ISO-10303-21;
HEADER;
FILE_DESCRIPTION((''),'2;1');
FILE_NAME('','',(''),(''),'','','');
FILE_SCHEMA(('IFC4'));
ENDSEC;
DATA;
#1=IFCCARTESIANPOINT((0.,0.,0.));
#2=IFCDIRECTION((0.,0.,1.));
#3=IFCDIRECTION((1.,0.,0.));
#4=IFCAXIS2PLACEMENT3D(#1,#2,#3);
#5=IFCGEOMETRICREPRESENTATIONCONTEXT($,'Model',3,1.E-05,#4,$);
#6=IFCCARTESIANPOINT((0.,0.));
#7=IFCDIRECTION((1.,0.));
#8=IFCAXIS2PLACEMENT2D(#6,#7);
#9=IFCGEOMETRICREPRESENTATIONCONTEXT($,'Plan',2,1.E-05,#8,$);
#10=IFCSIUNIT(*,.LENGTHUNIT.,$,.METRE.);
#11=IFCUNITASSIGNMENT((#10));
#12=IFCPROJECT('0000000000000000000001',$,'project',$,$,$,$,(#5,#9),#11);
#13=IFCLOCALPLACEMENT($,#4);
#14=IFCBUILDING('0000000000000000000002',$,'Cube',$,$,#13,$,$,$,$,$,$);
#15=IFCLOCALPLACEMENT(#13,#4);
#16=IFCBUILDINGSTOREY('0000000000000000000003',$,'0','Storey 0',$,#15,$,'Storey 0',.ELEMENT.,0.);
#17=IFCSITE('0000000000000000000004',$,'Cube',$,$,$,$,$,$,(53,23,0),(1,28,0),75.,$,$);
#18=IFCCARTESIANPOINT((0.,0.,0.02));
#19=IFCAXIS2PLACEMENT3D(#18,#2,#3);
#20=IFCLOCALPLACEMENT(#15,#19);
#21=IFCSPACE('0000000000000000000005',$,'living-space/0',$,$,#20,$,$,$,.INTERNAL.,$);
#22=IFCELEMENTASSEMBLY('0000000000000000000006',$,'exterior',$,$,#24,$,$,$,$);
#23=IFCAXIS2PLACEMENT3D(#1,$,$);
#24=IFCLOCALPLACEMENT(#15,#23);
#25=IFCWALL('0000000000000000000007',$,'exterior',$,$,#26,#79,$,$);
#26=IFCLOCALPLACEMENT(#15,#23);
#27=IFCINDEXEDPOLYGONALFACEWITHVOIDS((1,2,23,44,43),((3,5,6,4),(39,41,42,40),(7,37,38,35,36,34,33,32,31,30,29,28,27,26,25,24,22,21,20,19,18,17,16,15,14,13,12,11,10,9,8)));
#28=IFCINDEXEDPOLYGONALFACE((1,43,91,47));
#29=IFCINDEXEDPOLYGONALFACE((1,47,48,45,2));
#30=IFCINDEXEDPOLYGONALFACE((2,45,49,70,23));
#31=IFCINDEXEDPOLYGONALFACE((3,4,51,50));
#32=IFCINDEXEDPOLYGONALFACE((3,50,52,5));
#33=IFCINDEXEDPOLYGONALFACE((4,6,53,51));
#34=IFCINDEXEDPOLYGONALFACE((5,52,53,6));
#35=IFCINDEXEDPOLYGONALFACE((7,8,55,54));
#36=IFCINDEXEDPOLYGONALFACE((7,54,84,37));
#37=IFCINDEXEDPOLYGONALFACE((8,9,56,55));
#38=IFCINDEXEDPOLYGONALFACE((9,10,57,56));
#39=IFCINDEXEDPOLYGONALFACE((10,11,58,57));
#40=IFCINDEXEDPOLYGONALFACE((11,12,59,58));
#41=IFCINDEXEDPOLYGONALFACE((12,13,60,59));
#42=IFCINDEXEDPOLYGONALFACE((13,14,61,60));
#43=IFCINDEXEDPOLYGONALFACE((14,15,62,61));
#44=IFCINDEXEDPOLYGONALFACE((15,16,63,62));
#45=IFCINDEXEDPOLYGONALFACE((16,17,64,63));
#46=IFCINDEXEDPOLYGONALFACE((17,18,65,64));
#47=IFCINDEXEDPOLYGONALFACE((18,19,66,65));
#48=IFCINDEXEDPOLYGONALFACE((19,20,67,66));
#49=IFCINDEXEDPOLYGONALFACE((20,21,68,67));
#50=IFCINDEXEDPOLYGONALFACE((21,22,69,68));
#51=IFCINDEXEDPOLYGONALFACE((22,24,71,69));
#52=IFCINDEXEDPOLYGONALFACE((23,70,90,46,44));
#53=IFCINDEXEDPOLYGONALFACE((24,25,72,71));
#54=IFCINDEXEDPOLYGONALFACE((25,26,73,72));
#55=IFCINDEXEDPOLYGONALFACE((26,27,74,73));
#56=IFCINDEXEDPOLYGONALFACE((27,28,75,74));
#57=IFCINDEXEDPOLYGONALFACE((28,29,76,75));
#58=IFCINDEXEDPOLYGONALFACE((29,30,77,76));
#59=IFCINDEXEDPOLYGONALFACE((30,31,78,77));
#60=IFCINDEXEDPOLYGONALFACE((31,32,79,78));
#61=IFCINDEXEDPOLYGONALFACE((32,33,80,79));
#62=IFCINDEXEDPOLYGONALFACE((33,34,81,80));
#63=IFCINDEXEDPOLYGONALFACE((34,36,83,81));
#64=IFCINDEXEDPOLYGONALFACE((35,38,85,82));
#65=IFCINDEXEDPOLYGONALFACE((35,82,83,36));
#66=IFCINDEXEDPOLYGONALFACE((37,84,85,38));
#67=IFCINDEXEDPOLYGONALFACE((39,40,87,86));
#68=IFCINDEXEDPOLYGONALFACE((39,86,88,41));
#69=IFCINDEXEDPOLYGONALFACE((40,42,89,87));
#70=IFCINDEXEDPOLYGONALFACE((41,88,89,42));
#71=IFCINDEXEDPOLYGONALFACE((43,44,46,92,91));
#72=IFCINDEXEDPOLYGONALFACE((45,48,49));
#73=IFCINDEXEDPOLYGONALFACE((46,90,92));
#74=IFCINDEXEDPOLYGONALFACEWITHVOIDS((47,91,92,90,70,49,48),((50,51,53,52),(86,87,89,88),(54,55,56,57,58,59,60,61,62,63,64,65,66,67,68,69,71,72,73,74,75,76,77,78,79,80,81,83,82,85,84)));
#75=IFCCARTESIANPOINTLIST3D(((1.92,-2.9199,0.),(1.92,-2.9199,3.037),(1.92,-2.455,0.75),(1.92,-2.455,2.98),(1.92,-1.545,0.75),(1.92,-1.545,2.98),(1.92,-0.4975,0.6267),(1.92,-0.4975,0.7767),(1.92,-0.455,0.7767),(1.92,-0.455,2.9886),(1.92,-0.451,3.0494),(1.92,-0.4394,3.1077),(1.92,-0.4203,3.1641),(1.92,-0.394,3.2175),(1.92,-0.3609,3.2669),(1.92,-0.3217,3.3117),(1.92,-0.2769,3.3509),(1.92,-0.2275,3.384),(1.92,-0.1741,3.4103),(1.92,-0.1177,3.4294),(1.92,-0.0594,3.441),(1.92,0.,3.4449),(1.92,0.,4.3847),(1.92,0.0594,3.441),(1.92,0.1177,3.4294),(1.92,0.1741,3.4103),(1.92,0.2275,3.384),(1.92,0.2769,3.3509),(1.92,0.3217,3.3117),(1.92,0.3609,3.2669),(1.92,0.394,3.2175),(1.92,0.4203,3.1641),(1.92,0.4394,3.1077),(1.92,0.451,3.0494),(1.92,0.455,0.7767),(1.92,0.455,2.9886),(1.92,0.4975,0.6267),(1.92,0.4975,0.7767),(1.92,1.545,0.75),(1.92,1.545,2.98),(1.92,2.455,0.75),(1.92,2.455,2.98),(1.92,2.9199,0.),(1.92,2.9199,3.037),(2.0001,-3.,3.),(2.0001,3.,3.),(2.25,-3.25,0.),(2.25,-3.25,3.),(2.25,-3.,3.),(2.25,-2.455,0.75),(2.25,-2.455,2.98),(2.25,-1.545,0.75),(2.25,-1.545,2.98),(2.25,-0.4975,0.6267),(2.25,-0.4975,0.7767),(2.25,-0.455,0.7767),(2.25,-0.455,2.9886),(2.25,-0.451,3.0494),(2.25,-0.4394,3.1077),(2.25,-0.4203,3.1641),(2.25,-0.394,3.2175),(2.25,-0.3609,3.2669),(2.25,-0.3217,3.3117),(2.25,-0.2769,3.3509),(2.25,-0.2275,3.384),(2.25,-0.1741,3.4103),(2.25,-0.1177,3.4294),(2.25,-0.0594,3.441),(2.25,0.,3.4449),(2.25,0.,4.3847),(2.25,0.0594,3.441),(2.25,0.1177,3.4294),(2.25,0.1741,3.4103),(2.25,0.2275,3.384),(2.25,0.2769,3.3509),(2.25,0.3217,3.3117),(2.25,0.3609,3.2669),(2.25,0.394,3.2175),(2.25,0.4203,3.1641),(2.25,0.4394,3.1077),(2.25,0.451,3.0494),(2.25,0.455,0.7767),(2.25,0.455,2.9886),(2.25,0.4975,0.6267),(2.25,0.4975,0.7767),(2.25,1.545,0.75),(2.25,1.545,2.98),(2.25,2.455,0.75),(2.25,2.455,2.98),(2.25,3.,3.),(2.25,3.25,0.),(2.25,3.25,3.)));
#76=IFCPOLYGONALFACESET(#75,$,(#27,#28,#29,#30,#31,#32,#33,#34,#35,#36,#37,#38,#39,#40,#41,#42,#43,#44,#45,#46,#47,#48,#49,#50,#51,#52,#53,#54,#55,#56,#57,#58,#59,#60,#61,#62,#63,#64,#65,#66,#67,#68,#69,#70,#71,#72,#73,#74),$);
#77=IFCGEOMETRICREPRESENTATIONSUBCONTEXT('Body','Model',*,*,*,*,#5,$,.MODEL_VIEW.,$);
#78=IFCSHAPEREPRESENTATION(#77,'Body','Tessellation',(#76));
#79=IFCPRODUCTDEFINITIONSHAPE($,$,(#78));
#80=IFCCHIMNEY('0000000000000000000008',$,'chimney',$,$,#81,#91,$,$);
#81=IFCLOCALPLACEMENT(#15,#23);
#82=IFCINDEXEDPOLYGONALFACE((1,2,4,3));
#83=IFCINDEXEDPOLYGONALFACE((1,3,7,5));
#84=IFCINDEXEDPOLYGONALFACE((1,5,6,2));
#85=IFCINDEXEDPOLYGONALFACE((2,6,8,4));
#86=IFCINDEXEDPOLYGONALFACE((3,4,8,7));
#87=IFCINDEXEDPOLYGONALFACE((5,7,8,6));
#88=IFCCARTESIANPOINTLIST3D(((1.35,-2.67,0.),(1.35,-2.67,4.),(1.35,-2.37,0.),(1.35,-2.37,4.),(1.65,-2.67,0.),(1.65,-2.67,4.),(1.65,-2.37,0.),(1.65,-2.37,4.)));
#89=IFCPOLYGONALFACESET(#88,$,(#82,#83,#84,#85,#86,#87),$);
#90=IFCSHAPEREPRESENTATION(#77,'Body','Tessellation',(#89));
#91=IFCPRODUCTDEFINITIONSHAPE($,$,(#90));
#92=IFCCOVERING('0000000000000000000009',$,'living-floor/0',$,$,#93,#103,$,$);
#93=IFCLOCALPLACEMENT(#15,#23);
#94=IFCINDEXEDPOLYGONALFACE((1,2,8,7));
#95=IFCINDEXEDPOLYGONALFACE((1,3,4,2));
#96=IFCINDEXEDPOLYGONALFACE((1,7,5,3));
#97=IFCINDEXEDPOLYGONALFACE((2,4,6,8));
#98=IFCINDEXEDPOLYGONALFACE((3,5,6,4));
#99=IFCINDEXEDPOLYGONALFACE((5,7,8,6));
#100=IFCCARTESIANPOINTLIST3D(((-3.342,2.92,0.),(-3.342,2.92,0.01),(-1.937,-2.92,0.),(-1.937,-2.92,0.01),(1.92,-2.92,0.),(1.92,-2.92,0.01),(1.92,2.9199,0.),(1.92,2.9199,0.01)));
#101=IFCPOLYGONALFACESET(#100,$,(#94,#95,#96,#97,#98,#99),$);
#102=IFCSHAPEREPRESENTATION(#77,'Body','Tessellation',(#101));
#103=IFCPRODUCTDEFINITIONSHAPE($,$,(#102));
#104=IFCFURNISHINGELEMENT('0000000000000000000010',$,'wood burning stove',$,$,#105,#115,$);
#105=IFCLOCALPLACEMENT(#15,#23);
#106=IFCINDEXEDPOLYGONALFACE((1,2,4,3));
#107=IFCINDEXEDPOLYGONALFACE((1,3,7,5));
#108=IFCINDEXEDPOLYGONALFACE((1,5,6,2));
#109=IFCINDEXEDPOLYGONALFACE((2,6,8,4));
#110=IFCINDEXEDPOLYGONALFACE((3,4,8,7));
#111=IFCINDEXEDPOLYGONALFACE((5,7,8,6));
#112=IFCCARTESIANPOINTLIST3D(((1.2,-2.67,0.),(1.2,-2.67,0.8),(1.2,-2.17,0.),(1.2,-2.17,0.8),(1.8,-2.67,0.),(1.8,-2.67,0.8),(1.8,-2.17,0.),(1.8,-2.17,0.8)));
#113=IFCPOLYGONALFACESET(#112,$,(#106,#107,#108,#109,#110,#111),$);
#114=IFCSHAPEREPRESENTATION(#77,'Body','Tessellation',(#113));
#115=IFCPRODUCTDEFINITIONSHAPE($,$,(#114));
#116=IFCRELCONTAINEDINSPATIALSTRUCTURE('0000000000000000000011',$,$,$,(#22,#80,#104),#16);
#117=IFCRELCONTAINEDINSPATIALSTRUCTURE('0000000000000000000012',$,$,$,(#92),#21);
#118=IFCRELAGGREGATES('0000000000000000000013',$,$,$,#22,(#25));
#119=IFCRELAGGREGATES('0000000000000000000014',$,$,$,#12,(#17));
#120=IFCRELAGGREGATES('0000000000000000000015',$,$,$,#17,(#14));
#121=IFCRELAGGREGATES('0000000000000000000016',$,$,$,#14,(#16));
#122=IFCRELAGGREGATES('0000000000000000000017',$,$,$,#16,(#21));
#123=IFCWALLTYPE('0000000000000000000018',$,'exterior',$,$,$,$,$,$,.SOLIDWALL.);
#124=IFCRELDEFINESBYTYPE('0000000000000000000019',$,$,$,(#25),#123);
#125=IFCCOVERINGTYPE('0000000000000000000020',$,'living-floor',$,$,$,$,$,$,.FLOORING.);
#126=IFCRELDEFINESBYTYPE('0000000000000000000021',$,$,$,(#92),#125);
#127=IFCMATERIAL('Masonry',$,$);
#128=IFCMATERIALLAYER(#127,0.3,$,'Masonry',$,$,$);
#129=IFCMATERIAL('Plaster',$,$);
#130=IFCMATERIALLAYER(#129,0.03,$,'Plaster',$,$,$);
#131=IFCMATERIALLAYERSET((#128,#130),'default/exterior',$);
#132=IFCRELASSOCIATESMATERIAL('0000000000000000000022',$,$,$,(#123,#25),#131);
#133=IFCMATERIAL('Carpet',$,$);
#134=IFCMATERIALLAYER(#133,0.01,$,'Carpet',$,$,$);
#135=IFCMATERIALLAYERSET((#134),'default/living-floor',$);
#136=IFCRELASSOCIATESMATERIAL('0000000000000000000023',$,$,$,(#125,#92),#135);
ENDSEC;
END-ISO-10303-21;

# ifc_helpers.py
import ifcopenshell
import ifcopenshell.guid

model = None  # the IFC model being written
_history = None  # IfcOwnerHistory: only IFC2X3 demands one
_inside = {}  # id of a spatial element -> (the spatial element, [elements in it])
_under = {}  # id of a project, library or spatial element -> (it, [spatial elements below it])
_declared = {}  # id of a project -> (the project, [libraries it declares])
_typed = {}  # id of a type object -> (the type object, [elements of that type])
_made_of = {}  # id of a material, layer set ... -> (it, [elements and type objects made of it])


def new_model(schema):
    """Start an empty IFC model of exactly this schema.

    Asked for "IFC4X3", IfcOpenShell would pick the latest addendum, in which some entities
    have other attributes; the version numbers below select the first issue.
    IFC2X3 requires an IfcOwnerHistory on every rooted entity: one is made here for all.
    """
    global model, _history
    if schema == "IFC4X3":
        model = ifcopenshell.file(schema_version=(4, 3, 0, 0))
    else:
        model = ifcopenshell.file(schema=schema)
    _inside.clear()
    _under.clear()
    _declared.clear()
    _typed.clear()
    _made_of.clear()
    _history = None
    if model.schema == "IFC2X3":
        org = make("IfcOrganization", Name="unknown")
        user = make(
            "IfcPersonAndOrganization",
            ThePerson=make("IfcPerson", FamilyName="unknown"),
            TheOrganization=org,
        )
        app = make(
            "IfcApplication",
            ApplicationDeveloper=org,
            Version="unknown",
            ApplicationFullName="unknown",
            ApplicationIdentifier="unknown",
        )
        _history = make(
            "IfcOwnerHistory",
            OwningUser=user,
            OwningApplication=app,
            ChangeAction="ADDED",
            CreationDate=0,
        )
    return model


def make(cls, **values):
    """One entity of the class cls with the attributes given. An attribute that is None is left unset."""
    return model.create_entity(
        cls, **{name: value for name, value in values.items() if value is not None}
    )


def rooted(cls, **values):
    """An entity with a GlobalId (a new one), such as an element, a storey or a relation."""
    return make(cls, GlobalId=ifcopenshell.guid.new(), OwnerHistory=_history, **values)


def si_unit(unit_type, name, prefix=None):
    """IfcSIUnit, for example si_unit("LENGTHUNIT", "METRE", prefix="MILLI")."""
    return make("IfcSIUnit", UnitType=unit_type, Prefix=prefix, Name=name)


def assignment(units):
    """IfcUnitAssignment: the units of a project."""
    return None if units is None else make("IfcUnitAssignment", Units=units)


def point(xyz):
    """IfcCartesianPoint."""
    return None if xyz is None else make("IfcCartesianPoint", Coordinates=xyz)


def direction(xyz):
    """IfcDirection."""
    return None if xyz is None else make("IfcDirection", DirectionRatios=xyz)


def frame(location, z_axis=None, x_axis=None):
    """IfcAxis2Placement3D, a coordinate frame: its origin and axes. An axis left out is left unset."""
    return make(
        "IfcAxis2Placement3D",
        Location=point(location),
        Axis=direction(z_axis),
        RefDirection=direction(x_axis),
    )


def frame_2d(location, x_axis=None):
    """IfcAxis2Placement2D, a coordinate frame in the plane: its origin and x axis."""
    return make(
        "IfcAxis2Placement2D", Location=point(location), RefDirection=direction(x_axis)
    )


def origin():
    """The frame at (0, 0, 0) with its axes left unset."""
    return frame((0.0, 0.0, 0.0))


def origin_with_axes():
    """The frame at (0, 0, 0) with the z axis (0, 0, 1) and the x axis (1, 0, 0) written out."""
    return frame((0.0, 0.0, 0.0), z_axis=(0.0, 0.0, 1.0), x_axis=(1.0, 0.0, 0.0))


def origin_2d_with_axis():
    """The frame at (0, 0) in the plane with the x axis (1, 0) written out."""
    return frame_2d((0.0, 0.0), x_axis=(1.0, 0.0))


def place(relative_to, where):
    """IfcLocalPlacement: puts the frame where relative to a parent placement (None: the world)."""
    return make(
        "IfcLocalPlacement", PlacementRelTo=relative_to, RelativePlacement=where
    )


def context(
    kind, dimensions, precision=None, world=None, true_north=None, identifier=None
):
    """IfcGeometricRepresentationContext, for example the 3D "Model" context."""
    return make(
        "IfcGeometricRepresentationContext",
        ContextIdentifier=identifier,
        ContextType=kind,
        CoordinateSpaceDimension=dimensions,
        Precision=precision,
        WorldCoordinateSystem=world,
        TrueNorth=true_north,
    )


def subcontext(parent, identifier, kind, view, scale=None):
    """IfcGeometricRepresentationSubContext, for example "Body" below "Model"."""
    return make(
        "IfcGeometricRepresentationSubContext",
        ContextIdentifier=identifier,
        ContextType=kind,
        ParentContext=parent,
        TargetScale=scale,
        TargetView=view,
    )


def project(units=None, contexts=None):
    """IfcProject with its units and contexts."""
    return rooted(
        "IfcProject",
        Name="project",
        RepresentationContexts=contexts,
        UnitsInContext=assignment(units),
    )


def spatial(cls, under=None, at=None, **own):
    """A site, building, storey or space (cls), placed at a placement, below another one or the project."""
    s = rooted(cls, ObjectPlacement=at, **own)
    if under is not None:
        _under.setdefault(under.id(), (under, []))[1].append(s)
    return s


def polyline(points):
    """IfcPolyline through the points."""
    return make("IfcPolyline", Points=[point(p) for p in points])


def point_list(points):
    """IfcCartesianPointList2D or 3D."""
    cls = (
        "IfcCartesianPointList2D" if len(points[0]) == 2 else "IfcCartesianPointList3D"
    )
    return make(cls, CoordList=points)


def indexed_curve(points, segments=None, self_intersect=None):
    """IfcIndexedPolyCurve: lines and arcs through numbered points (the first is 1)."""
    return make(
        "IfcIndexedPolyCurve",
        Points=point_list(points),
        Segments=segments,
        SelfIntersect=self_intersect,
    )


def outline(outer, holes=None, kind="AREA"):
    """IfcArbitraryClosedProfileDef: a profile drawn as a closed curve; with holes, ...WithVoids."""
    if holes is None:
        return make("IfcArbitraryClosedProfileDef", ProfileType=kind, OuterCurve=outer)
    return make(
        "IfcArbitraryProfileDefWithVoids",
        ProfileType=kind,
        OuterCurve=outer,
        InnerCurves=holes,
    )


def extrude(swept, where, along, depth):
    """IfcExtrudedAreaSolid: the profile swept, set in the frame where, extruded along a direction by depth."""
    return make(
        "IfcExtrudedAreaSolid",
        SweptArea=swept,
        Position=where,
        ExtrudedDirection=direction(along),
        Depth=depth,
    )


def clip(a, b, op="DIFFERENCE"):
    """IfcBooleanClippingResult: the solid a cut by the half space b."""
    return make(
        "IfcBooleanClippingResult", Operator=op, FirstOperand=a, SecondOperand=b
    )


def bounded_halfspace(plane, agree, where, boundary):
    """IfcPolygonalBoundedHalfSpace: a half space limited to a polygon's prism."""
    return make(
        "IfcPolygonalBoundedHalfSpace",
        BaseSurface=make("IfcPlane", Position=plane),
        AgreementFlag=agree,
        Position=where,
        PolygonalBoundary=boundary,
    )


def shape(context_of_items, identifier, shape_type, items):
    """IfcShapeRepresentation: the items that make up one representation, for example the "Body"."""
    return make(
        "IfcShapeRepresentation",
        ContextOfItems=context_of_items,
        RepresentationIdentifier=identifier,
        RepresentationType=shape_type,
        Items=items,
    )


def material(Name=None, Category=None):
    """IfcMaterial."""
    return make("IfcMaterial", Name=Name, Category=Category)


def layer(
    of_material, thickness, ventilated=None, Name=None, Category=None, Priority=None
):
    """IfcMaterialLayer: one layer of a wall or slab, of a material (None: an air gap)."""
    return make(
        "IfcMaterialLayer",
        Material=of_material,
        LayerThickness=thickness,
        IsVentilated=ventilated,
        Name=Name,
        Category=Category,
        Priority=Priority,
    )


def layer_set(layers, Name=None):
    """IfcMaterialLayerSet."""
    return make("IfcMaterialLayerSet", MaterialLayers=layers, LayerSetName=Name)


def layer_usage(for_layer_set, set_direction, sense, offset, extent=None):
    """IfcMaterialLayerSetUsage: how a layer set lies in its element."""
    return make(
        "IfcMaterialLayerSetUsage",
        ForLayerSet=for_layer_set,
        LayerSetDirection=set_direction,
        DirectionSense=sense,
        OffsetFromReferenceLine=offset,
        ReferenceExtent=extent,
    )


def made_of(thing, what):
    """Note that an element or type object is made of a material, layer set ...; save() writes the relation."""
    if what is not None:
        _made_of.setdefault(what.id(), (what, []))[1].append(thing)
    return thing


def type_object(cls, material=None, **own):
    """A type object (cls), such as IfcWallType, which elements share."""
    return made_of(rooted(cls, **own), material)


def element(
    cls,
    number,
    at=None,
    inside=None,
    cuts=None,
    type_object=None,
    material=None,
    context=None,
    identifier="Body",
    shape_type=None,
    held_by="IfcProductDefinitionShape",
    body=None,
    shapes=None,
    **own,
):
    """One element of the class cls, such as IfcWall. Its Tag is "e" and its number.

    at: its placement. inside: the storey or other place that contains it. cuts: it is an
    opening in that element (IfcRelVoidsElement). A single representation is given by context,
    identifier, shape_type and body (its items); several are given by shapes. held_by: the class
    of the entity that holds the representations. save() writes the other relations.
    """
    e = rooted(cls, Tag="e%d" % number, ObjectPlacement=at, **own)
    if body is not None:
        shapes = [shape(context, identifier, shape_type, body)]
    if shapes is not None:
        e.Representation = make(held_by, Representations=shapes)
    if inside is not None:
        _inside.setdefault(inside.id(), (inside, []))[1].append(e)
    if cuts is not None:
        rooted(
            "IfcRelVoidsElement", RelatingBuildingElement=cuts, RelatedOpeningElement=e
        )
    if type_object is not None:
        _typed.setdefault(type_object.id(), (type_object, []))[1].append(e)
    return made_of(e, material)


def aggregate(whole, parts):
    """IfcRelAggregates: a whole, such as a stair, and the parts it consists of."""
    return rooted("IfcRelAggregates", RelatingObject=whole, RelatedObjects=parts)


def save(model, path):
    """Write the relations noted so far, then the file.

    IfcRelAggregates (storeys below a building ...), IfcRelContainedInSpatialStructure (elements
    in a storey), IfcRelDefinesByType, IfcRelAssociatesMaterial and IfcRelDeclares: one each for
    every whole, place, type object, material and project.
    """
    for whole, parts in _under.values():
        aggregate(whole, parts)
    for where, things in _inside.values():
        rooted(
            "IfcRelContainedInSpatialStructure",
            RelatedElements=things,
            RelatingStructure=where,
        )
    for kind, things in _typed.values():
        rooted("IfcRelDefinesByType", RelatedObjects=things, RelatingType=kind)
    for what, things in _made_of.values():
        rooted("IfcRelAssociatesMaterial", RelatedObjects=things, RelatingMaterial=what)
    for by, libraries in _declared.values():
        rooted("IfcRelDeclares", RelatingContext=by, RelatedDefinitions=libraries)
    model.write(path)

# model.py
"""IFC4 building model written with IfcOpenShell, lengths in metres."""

from ifc_helpers import new_model, si_unit, frame, origin, origin_with_axes, origin_2d_with_axis, place, context, subcontext, project, spatial, polyline, indexed_curve, outline, extrude, clip, bounded_halfspace, material, layer, layer_set, layer_usage, type_object, element, aggregate, save


model = new_model("IFC4")

# Units and contexts
model_context = context("Model", 3, precision=1e-05, world=origin_with_axes())
plan_context = context("Plan", 2, precision=1e-05, world=origin_2d_with_axis())
body_context = subcontext(model_context, "Body", "Model", "MODEL_VIEW")
ifc_project = project(units=[si_unit("LENGTHUNIT", "METRE")], contexts=[model_context, plan_context])

# Site, building, storey
site = spatial("IfcSite", under=ifc_project, Name="Cube", RefLatitude=(53, 23, 0), RefLongitude=(1, 28, 0), RefElevation=75.0)
building_placement = place(None, origin_with_axes())
building = spatial("IfcBuilding", under=site, at=building_placement, Name="Cube")
storey_placement = place(building_placement, origin_with_axes())
storey = spatial("IfcBuildingStorey", under=building, at=storey_placement, Name="0", Description="Storey 0", LongName="Storey 0", CompositionType="ELEMENT", Elevation=0.0)

# Element assembly, wall, openings
ifc_material_1 = material(Name="Masonry")
ifc_layer_1 = layer(ifc_material_1, 0.3, Name="Masonry")
ifc_material_2 = material(Name="Plaster")
ifc_layer_2 = layer(ifc_material_2, 0.03, Name="Plaster")
ifc_layer_set_1 = layer_set([ifc_layer_1, ifc_layer_2], Name="default/exterior")
wall_type = type_object("IfcWallType", Name="exterior", PredefinedType="SOLIDWALL", material=ifc_layer_set_1)
assembly_1_placement = place(storey_placement, frame((2.0, -3.0, 0.0), z_axis=(0.0, 0.0, 1.0), x_axis=(0.0, 1.0, 0.0)))
assembly_1 = element("IfcElementAssembly", 1, at=assembly_1_placement, inside=storey, Name="exterior")
ifc_layer_usage_1 = layer_usage(ifc_layer_set_1, "AXIS2", "POSITIVE", -0.25)
wall_1_placement = place(assembly_1_placement, origin_with_axes())
wall_1 = element("IfcWall", 2, at=wall_1_placement, type_object=wall_type, material=ifc_layer_usage_1, Name="exterior", context=body_context, shape_type="Clipping", body=[
    clip(clip(clip(clip(extrude(outline(polyline([(0.0801, 0.08), (-0.25, -0.25), (6.25, -0.25), (5.9199, 0.08), (0.0801, 0.08)])), origin(), (0.0, 0.0, 1.0), 4.385), bounded_halfspace(frame((6.0, 0.0, 3.0), z_axis=(0.419069, 0.0, 0.907954), x_axis=(0.0, -1.0, 0.0)), False, origin(), polyline([(6.0, -1.0), (3.0, -1.0), (3.0, 1.0), (6.0, 1.0), (6.0, -1.0)]))), bounded_halfspace(frame((6.0, 0.0, 3.0), z_axis=(0.0, 0.0, 1.0), x_axis=(0.0, 1.0, 0.0)), False, origin(), polyline([(6.0, 1.0), (7.0, 1.0), (7.0, -1.0), (6.0, -1.0), (6.0, 1.0)]))), bounded_halfspace(frame((3.0, 0.0, 4.3847), z_axis=(-0.419069, 0.0, 0.907954), x_axis=(0.0, -1.0, 0.0)), False, origin(), polyline([(3.0, -1.0), (0.0, -1.0), (0.0, 1.0), (3.0, 1.0), (3.0, -1.0)]))), bounded_halfspace(frame((0.0, 0.0, 3.0), z_axis=(0.0, 0.0, 1.0), x_axis=(0.0, -1.0, 0.0)), False, origin(), polyline([(0.0, -1.0), (-1.0, -1.0), (-1.0, 1.0), (0.0, 1.0), (0.0, -1.0)]))),
])
opening_1_placement = place(wall_1_placement, frame((0.545, -0.25, 0.75), z_axis=(0.0, 0.0, 1.0), x_axis=(1.0, 0.0, 0.0)))
element("IfcOpeningElement", 3, at=opening_1_placement, cuts=wall_1, PredefinedType="OPENING", context=body_context, shape_type="SweptSolid", body=[
    extrude(outline(polyline([(0.0, -0.02), (0.91, -0.02), (0.91, 0.35), (0.0, 0.35), (0.0, -0.02)])), origin(), (0.0, 0.0, 1.0), 2.23),
])
opening_2_placement = place(wall_1_placement, frame((2.545, -0.25, 0.75), z_axis=(0.0, 0.0, 1.0), x_axis=(1.0, 0.0, 0.0)))
element("IfcOpeningElement", 4, at=opening_2_placement, cuts=wall_1, PredefinedType="OPENING", context=body_context, shape_type="SweptSolid", body=[
    extrude(outline(polyline([(0.1333, 2.5617), (0.1781, 2.6009), (0.2275, 2.634), (0.2809, 2.6603), (0.3373, 2.6794), (0.3956, 2.691), (0.455, 2.6949), (0.5144, 2.691), (0.5727, 2.6794), (0.6291, 2.6603), (0.6825, 2.634), (0.7319, 2.6009), (0.7767, 2.5617), (0.8159, 2.5169), (0.849, 2.4675), (0.8753, 2.4141), (0.8944, 2.3577), (0.906, 2.2994), (0.91, 2.2386), (0.91, 2.2069), (0.91, 0.0267), (0.9525, 0.0267), (0.9525, -0.1233), (-0.0425, -0.1233), (-0.0425, 0.0267), (0.0, 0.0267), (0.0, 2.2069), (0.0, 2.2386), (0.004, 2.2994), (0.0156, 2.3577), (0.0347, 2.4141), (0.061, 2.4675), (0.0941, 2.5169), (0.1333, 2.5617)])), frame((0.0, -0.02, 0.0), z_axis=(0.0, -1.0, 0.0), x_axis=(1.0, 0.0, 0.0)), (0.0, 0.0, -1.0), 0.37),
])
opening_3_placement = place(wall_1_placement, frame((4.545, -0.25, 0.75), z_axis=(0.0, 0.0, 1.0), x_axis=(1.0, 0.0, 0.0)))
element("IfcOpeningElement", 5, at=opening_3_placement, cuts=wall_1, PredefinedType="OPENING", context=body_context, shape_type="SweptSolid", body=[
    extrude(outline(polyline([(0.0, -0.02), (0.91, -0.02), (0.91, 0.35), (0.0, 0.35), (0.0, -0.02)])), origin(), (0.0, 0.0, 1.0), 2.23),
])
aggregate(assembly_1, [wall_1])

# Chimney
chimney_placement = place(storey_placement, frame((1.35, -2.67, 0.0), z_axis=(0.0, 0.0, 1.0), x_axis=(1.0, 0.0, 0.0)))
element("IfcChimney", 6, at=chimney_placement, inside=storey, Name="chimney", context=body_context, shape_type="SweptSolid", body=[
    extrude(outline(indexed_curve([(0.0, 0.0), (0.3, 0.0), (0.3, 0.3), (0.0, 0.3)])), None, (0.0, 0.0, 1.0), 4.0),
])

# Shared definitions
space_placement = place(storey_placement, frame((0.0, 0.0, 0.02), z_axis=(0.0, 0.0, 1.0), x_axis=(1.0, 0.0, 0.0)))
space = spatial("IfcSpace", under=storey, at=space_placement, Name="living-space/0", PredefinedType="INTERNAL")

# Covering
ifc_material_3 = material(Name="Carpet")
ifc_layer_3 = layer(ifc_material_3, 0.01, Name="Carpet")
ifc_layer_set_2 = layer_set([ifc_layer_3], Name="default/living-floor")
ifc_layer_usage_2 = layer_usage(ifc_layer_set_2, "AXIS3", "POSITIVE", 0.0)
covering_type = type_object("IfcCoveringType", Name="living-floor", PredefinedType="FLOORING", material=ifc_layer_set_2)
covering_placement = place(space_placement, frame((0.0, 0.0, -0.02), z_axis=(0.0, 0.0, 1.0), x_axis=(1.0, 0.0, 0.0)))
element("IfcCovering", 7, at=covering_placement, inside=space, type_object=covering_type, material=ifc_layer_usage_2, Name="living-floor/0", context=body_context, shape_type="SweptSolid", body=[
    extrude(outline(polyline([(1.92, 2.9199), (-3.342, 2.92), (-1.937, -2.92), (1.92, -2.92), (1.92, 2.9199)])), origin_with_axes(), (0.0, 0.0, 1.0), 0.01),
])

# Furnishing element
furnishing_placement = place(storey_placement, frame((1.2, -2.67, 0.0), z_axis=(0.0, 0.0, 1.0), x_axis=(1.0, 0.0, 0.0)))
element("IfcFurnishingElement", 8, at=furnishing_placement, inside=storey, Name="wood burning stove", context=body_context, shape_type="SweptSolid", body=[
    extrude(outline(indexed_curve([(0.0, 0.0), (0.6, 0.0), (0.6, 0.5), (0.0, 0.5)])), None, (0.0, 0.0, 1.0), 0.8),
])

save(model, "model.ifc")
